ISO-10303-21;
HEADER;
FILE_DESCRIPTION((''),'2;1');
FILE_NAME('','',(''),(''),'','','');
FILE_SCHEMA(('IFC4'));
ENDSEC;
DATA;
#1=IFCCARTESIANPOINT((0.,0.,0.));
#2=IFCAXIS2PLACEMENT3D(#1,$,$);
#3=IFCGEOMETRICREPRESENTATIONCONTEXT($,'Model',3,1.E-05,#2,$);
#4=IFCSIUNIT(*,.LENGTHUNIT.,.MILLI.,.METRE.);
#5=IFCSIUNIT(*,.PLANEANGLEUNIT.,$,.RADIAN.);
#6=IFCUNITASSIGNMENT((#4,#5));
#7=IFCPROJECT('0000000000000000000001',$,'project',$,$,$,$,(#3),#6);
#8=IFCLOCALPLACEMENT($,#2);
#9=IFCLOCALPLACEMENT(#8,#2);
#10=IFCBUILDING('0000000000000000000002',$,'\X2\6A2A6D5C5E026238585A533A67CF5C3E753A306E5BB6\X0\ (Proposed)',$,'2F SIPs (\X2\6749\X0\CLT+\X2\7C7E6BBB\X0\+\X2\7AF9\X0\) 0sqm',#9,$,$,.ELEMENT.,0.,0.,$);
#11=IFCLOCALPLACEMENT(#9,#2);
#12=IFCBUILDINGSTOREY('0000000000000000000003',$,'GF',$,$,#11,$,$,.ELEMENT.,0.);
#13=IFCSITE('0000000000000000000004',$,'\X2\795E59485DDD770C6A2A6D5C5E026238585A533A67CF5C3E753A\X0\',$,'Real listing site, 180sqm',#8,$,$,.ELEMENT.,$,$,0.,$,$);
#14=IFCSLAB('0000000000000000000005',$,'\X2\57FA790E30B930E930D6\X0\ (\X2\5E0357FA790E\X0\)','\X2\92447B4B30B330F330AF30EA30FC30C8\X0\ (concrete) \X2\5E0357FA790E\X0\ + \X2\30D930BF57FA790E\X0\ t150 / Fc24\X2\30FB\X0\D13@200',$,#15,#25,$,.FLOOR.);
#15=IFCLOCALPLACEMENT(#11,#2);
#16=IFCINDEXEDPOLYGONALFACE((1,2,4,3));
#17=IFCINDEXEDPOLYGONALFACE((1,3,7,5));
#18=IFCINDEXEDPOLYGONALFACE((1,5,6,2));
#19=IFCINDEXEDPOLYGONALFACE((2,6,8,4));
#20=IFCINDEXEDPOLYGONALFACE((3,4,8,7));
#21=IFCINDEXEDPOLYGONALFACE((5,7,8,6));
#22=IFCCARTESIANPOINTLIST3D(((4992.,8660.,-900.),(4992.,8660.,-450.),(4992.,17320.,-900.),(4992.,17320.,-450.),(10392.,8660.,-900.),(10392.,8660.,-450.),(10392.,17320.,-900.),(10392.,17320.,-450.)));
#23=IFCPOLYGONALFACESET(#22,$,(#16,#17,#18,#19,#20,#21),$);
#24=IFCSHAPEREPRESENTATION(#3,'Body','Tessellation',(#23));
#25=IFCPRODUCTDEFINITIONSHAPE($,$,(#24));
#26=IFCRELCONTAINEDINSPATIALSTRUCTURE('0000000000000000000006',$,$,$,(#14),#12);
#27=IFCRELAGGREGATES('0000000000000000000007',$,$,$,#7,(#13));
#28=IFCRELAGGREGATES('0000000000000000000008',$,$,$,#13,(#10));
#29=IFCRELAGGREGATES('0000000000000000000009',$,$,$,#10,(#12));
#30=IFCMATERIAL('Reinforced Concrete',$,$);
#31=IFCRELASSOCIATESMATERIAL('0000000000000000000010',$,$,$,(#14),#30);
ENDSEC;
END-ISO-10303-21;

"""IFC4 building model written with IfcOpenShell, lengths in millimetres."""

from ifc_helpers import new_model, si_unit, frame, frame_2d, origin, place, context, project, spatial, rectangle, extrude, material, element, save


model = new_model("IFC4")

# Units and contexts
model_context = context("Model", 3, precision=1e-05, world=origin())
ifc_project = project(units=[si_unit("LENGTHUNIT", "METRE", prefix="MILLI"), si_unit("PLANEANGLEUNIT", "RADIAN")], contexts=[model_context])

# Site, building, storey
site_placement = place(None, origin())
site = spatial("IfcSite", under=ifc_project, at=site_placement, Name="神奈川県横浜市戸塚区柏尾町", ObjectType="Real listing site, 180sqm", CompositionType="ELEMENT", RefElevation=0.0)
building_placement = place(site_placement, origin())
building = spatial("IfcBuilding", under=site, at=building_placement, Name="横浜市戸塚区柏尾町の家 (Proposed)", ObjectType="2F SIPs (杉CLT+籾殻+竹) 0sqm", CompositionType="ELEMENT", ElevationOfRefHeight=0.0, ElevationOfTerrain=0.0)
storey_placement = place(building_placement, origin())
storey = spatial("IfcBuildingStorey", under=building, at=storey_placement, Name="GF", CompositionType="ELEMENT", Elevation=0.0)

# Slab
ifc_material_1 = material(Name="Reinforced Concrete")
slab_1_placement = place(storey_placement, frame((2496.0, 4330.0, -450.0)))
element("IfcSlab", 1, at=slab_1_placement, inside=storey, material=ifc_material_1, Name="基礎スラブ (布基礎)", Description="鉄筋コンクリート (concrete) 布基礎 + ベタ基礎 t150 / Fc24・D13@200", PredefinedType="FLOOR", context=model_context, shape_type="SweptSolid", body=[
    extrude(rectangle(XDim=5400.0, YDim=8660.0, at=frame_2d((2700.0, 4330.0))), frame((2496.0, 4330.0, -450.0)), (0.0, 0.0, 1.0), 450.0),
])

save(model, "model.ifc")
